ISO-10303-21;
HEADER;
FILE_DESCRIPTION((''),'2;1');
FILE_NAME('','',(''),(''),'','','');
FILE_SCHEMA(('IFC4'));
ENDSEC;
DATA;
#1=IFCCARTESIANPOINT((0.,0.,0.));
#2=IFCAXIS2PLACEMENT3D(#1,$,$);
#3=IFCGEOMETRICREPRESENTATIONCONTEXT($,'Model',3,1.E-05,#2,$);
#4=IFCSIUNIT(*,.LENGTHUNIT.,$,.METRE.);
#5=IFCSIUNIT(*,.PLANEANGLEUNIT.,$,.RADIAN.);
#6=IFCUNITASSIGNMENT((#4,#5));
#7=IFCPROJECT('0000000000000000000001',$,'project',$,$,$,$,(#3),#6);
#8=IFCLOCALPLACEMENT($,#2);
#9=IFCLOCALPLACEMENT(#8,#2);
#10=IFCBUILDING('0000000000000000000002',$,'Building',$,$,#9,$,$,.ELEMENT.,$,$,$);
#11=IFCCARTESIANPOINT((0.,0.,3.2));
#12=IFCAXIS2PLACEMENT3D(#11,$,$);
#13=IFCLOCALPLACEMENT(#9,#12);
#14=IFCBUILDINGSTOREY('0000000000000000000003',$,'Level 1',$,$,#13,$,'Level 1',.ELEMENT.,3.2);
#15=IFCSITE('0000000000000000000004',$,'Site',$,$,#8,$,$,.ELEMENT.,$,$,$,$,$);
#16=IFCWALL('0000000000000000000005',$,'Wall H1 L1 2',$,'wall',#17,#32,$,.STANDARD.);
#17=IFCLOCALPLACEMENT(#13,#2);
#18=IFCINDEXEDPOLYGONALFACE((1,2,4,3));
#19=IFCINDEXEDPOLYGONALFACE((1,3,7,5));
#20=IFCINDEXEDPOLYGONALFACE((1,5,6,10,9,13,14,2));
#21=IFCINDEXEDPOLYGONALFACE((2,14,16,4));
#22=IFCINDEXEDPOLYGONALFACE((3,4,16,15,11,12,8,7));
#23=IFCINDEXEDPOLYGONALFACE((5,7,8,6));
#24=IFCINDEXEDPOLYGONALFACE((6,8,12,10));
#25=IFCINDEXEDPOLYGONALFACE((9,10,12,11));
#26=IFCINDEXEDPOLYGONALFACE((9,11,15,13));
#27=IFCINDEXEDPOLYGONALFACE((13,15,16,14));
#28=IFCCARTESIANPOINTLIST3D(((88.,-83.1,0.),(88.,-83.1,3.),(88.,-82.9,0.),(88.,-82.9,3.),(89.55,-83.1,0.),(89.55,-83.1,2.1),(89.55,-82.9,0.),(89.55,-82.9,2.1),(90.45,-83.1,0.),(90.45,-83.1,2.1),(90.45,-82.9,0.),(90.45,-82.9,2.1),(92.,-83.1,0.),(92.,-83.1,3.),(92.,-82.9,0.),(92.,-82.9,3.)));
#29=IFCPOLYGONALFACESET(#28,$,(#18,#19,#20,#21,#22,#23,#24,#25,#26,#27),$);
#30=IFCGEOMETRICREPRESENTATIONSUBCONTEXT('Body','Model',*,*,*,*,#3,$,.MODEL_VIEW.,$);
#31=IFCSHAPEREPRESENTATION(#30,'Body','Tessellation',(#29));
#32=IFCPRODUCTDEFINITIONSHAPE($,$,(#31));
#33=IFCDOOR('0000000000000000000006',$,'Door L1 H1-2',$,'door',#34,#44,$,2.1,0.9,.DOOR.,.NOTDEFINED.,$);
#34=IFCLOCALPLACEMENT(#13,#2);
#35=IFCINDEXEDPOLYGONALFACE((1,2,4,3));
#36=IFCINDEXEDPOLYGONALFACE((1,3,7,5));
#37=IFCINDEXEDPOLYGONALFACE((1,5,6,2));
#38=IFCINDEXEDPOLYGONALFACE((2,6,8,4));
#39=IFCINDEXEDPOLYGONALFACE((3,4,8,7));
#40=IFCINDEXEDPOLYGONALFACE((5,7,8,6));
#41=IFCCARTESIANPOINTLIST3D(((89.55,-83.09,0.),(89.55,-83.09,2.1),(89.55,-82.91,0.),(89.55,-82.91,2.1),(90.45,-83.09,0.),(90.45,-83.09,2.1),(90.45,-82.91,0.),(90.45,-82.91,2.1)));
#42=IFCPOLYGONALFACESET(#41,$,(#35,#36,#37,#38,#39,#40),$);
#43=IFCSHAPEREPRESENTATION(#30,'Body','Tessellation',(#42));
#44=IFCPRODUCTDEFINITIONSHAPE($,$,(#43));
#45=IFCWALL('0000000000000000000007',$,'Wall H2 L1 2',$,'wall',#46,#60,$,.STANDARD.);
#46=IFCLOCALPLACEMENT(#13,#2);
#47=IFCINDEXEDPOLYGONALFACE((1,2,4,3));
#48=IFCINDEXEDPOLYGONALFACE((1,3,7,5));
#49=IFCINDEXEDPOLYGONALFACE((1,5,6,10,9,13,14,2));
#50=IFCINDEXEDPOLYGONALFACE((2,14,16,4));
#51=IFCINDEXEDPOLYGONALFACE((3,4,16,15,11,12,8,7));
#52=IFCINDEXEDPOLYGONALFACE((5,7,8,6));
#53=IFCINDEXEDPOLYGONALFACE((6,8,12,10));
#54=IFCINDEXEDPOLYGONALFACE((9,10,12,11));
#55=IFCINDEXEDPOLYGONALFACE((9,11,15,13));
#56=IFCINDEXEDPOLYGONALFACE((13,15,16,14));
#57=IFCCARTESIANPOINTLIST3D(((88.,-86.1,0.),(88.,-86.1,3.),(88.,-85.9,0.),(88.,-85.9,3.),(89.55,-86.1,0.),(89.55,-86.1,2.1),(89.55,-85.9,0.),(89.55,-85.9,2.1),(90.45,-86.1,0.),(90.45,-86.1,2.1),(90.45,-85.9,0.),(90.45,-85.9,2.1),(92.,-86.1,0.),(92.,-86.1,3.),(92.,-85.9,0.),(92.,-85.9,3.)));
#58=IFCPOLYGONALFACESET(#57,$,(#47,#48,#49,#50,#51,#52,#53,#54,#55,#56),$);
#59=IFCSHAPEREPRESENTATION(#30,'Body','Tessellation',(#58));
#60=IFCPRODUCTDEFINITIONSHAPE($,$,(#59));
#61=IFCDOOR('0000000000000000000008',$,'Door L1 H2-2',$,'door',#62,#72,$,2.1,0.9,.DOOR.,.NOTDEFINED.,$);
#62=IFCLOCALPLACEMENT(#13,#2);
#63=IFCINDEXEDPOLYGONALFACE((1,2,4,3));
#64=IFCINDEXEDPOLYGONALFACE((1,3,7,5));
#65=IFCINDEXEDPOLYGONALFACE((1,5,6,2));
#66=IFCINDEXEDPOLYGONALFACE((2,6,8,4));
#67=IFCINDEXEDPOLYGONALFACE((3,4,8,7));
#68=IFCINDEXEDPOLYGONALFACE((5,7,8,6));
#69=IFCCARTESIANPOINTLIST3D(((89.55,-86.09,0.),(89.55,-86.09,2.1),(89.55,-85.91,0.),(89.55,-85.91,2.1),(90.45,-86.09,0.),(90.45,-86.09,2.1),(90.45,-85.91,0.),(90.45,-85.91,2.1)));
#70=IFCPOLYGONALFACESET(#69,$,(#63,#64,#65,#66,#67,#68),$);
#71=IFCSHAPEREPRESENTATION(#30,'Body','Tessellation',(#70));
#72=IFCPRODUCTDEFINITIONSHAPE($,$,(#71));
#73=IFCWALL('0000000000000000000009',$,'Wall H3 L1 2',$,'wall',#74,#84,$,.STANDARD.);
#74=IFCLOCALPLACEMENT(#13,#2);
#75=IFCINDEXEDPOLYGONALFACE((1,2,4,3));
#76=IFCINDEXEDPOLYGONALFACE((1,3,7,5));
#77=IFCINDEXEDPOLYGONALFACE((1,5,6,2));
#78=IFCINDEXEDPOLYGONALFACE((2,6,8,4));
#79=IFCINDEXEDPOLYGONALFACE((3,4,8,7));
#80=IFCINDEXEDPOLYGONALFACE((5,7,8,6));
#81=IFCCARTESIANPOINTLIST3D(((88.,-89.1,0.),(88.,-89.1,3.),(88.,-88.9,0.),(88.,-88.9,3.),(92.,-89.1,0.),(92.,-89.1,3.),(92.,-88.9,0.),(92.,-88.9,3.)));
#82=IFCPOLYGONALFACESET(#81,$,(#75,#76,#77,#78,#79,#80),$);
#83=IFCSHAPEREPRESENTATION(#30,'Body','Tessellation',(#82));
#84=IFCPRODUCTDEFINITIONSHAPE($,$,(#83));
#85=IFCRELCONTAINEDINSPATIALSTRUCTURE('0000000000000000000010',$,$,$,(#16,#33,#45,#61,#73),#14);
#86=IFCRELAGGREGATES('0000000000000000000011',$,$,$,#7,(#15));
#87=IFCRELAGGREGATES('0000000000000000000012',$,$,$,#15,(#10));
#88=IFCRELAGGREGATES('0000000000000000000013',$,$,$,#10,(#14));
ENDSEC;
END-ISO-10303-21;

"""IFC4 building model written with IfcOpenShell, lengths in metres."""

from ifc_helpers import new_model, si_unit, frame, frame_2d, origin, origin_2d, place, context, subcontext, project, spatial, rectangle, extrude, element, fill, save


model = new_model("IFC4")

# Units and contexts
model_context = context("Model", 3, precision=1e-05, world=origin())
body_context = subcontext(model_context, "Body", "Model", "MODEL_VIEW")
ifc_project = project(units=[si_unit("LENGTHUNIT", "METRE"), si_unit("PLANEANGLEUNIT", "RADIAN")], contexts=[model_context])

# Site, building, storey
site_placement = place(None, origin())
site = spatial("IfcSite", under=ifc_project, at=site_placement, Name="Site", CompositionType="ELEMENT")
building_placement = place(site_placement, origin())
building = spatial("IfcBuilding", under=site, at=building_placement, Name="Building", CompositionType="ELEMENT")
storey_placement = place(building_placement, frame((0.0, 0.0, 3.2)))
storey = spatial("IfcBuildingStorey", under=building, at=storey_placement, Name="Level 1", LongName="Level 1", CompositionType="ELEMENT", Elevation=3.2)

# Walls, openings, doors
wall_1_placement = place(storey_placement, frame((88.0, -83.0, 0.0), z_axis=(0.0, 0.0, 1.0), x_axis=(1.0, 0.0, 0.0)))
wall_1 = element("IfcWall", 1, at=wall_1_placement, inside=storey, Name="Wall H1 L1 2", ObjectType="wall", PredefinedType="STANDARD", context=body_context, shape_type="SweptSolid", body=[
    extrude(rectangle(XDim=4.0, YDim=0.2, at=frame_2d((2.0, 0.0))), origin(), (0.0, 0.0, 1.0), 3.0),
])
opening_1_placement = place(storey_placement, frame((90.0, -83.0, 0.0), z_axis=(0.0, 0.0, 1.0), x_axis=(1.0, 0.0, 0.0)))
opening_1 = element("IfcOpeningElement", 2, at=opening_1_placement, cuts=wall_1, ObjectType="Opening", PredefinedType="OPENING", context=body_context, shape_type="SweptSolid", body=[
    extrude(rectangle(XDim=0.9, YDim=0.22, at=origin_2d()), origin(), (0.0, 0.0, 1.0), 2.1),
])
door_1_placement = place(storey_placement, frame((90.0, -83.0, 0.0), z_axis=(0.0, 0.0, 1.0), x_axis=(1.0, 0.0, 0.0)))
door_1 = element("IfcDoor", 3, at=door_1_placement, inside=storey, Name="Door L1 H1-2", ObjectType="door", OperationType="NOTDEFINED", OverallHeight=2.1, OverallWidth=0.9, PredefinedType="DOOR", context=body_context, shape_type="SweptSolid", body=[
    extrude(rectangle(XDim=0.9, YDim=0.18, at=origin_2d()), origin(), (0.0, 0.0, 1.0), 2.1),
])
fill(opening_1, door_1)
wall_2_placement = place(storey_placement, frame((88.0, -86.0, 0.0), z_axis=(0.0, 0.0, 1.0), x_axis=(1.0, 0.0, 0.0)))
wall_2 = element("IfcWall", 4, at=wall_2_placement, inside=storey, Name="Wall H2 L1 2", ObjectType="wall", PredefinedType="STANDARD", context=body_context, shape_type="SweptSolid", body=[
    extrude(rectangle(XDim=4.0, YDim=0.2, at=frame_2d((2.0, 0.0))), origin(), (0.0, 0.0, 1.0), 3.0),
])
opening_2_placement = place(storey_placement, frame((90.0, -86.0, 0.0), z_axis=(0.0, 0.0, 1.0), x_axis=(1.0, 0.0, 0.0)))
opening_2 = element("IfcOpeningElement", 5, at=opening_2_placement, cuts=wall_2, ObjectType="Opening", PredefinedType="OPENING", context=body_context, shape_type="SweptSolid", body=[
    extrude(rectangle(XDim=0.9, YDim=0.22, at=origin_2d()), origin(), (0.0, 0.0, 1.0), 2.1),
])
door_2_placement = place(storey_placement, frame((90.0, -86.0, 0.0), z_axis=(0.0, 0.0, 1.0), x_axis=(1.0, 0.0, 0.0)))
door_2 = element("IfcDoor", 6, at=door_2_placement, inside=storey, Name="Door L1 H2-2", ObjectType="door", OperationType="NOTDEFINED", OverallHeight=2.1, OverallWidth=0.9, PredefinedType="DOOR", context=body_context, shape_type="SweptSolid", body=[
    extrude(rectangle(XDim=0.9, YDim=0.18, at=origin_2d()), origin(), (0.0, 0.0, 1.0), 2.1),
])
fill(opening_2, door_2)

# Wall
wall_3_placement = place(storey_placement, frame((88.0, -89.0, 0.0), z_axis=(0.0, 0.0, 1.0), x_axis=(1.0, 0.0, 0.0)))
element("IfcWall", 7, at=wall_3_placement, inside=storey, Name="Wall H3 L1 2", ObjectType="wall", PredefinedType="STANDARD", context=body_context, shape_type="SweptSolid", body=[
    extrude(rectangle(XDim=4.0, YDim=0.2, at=frame_2d((2.0, 0.0))), origin(), (0.0, 0.0, 1.0), 3.0),
])

save(model, "model.ifc")
